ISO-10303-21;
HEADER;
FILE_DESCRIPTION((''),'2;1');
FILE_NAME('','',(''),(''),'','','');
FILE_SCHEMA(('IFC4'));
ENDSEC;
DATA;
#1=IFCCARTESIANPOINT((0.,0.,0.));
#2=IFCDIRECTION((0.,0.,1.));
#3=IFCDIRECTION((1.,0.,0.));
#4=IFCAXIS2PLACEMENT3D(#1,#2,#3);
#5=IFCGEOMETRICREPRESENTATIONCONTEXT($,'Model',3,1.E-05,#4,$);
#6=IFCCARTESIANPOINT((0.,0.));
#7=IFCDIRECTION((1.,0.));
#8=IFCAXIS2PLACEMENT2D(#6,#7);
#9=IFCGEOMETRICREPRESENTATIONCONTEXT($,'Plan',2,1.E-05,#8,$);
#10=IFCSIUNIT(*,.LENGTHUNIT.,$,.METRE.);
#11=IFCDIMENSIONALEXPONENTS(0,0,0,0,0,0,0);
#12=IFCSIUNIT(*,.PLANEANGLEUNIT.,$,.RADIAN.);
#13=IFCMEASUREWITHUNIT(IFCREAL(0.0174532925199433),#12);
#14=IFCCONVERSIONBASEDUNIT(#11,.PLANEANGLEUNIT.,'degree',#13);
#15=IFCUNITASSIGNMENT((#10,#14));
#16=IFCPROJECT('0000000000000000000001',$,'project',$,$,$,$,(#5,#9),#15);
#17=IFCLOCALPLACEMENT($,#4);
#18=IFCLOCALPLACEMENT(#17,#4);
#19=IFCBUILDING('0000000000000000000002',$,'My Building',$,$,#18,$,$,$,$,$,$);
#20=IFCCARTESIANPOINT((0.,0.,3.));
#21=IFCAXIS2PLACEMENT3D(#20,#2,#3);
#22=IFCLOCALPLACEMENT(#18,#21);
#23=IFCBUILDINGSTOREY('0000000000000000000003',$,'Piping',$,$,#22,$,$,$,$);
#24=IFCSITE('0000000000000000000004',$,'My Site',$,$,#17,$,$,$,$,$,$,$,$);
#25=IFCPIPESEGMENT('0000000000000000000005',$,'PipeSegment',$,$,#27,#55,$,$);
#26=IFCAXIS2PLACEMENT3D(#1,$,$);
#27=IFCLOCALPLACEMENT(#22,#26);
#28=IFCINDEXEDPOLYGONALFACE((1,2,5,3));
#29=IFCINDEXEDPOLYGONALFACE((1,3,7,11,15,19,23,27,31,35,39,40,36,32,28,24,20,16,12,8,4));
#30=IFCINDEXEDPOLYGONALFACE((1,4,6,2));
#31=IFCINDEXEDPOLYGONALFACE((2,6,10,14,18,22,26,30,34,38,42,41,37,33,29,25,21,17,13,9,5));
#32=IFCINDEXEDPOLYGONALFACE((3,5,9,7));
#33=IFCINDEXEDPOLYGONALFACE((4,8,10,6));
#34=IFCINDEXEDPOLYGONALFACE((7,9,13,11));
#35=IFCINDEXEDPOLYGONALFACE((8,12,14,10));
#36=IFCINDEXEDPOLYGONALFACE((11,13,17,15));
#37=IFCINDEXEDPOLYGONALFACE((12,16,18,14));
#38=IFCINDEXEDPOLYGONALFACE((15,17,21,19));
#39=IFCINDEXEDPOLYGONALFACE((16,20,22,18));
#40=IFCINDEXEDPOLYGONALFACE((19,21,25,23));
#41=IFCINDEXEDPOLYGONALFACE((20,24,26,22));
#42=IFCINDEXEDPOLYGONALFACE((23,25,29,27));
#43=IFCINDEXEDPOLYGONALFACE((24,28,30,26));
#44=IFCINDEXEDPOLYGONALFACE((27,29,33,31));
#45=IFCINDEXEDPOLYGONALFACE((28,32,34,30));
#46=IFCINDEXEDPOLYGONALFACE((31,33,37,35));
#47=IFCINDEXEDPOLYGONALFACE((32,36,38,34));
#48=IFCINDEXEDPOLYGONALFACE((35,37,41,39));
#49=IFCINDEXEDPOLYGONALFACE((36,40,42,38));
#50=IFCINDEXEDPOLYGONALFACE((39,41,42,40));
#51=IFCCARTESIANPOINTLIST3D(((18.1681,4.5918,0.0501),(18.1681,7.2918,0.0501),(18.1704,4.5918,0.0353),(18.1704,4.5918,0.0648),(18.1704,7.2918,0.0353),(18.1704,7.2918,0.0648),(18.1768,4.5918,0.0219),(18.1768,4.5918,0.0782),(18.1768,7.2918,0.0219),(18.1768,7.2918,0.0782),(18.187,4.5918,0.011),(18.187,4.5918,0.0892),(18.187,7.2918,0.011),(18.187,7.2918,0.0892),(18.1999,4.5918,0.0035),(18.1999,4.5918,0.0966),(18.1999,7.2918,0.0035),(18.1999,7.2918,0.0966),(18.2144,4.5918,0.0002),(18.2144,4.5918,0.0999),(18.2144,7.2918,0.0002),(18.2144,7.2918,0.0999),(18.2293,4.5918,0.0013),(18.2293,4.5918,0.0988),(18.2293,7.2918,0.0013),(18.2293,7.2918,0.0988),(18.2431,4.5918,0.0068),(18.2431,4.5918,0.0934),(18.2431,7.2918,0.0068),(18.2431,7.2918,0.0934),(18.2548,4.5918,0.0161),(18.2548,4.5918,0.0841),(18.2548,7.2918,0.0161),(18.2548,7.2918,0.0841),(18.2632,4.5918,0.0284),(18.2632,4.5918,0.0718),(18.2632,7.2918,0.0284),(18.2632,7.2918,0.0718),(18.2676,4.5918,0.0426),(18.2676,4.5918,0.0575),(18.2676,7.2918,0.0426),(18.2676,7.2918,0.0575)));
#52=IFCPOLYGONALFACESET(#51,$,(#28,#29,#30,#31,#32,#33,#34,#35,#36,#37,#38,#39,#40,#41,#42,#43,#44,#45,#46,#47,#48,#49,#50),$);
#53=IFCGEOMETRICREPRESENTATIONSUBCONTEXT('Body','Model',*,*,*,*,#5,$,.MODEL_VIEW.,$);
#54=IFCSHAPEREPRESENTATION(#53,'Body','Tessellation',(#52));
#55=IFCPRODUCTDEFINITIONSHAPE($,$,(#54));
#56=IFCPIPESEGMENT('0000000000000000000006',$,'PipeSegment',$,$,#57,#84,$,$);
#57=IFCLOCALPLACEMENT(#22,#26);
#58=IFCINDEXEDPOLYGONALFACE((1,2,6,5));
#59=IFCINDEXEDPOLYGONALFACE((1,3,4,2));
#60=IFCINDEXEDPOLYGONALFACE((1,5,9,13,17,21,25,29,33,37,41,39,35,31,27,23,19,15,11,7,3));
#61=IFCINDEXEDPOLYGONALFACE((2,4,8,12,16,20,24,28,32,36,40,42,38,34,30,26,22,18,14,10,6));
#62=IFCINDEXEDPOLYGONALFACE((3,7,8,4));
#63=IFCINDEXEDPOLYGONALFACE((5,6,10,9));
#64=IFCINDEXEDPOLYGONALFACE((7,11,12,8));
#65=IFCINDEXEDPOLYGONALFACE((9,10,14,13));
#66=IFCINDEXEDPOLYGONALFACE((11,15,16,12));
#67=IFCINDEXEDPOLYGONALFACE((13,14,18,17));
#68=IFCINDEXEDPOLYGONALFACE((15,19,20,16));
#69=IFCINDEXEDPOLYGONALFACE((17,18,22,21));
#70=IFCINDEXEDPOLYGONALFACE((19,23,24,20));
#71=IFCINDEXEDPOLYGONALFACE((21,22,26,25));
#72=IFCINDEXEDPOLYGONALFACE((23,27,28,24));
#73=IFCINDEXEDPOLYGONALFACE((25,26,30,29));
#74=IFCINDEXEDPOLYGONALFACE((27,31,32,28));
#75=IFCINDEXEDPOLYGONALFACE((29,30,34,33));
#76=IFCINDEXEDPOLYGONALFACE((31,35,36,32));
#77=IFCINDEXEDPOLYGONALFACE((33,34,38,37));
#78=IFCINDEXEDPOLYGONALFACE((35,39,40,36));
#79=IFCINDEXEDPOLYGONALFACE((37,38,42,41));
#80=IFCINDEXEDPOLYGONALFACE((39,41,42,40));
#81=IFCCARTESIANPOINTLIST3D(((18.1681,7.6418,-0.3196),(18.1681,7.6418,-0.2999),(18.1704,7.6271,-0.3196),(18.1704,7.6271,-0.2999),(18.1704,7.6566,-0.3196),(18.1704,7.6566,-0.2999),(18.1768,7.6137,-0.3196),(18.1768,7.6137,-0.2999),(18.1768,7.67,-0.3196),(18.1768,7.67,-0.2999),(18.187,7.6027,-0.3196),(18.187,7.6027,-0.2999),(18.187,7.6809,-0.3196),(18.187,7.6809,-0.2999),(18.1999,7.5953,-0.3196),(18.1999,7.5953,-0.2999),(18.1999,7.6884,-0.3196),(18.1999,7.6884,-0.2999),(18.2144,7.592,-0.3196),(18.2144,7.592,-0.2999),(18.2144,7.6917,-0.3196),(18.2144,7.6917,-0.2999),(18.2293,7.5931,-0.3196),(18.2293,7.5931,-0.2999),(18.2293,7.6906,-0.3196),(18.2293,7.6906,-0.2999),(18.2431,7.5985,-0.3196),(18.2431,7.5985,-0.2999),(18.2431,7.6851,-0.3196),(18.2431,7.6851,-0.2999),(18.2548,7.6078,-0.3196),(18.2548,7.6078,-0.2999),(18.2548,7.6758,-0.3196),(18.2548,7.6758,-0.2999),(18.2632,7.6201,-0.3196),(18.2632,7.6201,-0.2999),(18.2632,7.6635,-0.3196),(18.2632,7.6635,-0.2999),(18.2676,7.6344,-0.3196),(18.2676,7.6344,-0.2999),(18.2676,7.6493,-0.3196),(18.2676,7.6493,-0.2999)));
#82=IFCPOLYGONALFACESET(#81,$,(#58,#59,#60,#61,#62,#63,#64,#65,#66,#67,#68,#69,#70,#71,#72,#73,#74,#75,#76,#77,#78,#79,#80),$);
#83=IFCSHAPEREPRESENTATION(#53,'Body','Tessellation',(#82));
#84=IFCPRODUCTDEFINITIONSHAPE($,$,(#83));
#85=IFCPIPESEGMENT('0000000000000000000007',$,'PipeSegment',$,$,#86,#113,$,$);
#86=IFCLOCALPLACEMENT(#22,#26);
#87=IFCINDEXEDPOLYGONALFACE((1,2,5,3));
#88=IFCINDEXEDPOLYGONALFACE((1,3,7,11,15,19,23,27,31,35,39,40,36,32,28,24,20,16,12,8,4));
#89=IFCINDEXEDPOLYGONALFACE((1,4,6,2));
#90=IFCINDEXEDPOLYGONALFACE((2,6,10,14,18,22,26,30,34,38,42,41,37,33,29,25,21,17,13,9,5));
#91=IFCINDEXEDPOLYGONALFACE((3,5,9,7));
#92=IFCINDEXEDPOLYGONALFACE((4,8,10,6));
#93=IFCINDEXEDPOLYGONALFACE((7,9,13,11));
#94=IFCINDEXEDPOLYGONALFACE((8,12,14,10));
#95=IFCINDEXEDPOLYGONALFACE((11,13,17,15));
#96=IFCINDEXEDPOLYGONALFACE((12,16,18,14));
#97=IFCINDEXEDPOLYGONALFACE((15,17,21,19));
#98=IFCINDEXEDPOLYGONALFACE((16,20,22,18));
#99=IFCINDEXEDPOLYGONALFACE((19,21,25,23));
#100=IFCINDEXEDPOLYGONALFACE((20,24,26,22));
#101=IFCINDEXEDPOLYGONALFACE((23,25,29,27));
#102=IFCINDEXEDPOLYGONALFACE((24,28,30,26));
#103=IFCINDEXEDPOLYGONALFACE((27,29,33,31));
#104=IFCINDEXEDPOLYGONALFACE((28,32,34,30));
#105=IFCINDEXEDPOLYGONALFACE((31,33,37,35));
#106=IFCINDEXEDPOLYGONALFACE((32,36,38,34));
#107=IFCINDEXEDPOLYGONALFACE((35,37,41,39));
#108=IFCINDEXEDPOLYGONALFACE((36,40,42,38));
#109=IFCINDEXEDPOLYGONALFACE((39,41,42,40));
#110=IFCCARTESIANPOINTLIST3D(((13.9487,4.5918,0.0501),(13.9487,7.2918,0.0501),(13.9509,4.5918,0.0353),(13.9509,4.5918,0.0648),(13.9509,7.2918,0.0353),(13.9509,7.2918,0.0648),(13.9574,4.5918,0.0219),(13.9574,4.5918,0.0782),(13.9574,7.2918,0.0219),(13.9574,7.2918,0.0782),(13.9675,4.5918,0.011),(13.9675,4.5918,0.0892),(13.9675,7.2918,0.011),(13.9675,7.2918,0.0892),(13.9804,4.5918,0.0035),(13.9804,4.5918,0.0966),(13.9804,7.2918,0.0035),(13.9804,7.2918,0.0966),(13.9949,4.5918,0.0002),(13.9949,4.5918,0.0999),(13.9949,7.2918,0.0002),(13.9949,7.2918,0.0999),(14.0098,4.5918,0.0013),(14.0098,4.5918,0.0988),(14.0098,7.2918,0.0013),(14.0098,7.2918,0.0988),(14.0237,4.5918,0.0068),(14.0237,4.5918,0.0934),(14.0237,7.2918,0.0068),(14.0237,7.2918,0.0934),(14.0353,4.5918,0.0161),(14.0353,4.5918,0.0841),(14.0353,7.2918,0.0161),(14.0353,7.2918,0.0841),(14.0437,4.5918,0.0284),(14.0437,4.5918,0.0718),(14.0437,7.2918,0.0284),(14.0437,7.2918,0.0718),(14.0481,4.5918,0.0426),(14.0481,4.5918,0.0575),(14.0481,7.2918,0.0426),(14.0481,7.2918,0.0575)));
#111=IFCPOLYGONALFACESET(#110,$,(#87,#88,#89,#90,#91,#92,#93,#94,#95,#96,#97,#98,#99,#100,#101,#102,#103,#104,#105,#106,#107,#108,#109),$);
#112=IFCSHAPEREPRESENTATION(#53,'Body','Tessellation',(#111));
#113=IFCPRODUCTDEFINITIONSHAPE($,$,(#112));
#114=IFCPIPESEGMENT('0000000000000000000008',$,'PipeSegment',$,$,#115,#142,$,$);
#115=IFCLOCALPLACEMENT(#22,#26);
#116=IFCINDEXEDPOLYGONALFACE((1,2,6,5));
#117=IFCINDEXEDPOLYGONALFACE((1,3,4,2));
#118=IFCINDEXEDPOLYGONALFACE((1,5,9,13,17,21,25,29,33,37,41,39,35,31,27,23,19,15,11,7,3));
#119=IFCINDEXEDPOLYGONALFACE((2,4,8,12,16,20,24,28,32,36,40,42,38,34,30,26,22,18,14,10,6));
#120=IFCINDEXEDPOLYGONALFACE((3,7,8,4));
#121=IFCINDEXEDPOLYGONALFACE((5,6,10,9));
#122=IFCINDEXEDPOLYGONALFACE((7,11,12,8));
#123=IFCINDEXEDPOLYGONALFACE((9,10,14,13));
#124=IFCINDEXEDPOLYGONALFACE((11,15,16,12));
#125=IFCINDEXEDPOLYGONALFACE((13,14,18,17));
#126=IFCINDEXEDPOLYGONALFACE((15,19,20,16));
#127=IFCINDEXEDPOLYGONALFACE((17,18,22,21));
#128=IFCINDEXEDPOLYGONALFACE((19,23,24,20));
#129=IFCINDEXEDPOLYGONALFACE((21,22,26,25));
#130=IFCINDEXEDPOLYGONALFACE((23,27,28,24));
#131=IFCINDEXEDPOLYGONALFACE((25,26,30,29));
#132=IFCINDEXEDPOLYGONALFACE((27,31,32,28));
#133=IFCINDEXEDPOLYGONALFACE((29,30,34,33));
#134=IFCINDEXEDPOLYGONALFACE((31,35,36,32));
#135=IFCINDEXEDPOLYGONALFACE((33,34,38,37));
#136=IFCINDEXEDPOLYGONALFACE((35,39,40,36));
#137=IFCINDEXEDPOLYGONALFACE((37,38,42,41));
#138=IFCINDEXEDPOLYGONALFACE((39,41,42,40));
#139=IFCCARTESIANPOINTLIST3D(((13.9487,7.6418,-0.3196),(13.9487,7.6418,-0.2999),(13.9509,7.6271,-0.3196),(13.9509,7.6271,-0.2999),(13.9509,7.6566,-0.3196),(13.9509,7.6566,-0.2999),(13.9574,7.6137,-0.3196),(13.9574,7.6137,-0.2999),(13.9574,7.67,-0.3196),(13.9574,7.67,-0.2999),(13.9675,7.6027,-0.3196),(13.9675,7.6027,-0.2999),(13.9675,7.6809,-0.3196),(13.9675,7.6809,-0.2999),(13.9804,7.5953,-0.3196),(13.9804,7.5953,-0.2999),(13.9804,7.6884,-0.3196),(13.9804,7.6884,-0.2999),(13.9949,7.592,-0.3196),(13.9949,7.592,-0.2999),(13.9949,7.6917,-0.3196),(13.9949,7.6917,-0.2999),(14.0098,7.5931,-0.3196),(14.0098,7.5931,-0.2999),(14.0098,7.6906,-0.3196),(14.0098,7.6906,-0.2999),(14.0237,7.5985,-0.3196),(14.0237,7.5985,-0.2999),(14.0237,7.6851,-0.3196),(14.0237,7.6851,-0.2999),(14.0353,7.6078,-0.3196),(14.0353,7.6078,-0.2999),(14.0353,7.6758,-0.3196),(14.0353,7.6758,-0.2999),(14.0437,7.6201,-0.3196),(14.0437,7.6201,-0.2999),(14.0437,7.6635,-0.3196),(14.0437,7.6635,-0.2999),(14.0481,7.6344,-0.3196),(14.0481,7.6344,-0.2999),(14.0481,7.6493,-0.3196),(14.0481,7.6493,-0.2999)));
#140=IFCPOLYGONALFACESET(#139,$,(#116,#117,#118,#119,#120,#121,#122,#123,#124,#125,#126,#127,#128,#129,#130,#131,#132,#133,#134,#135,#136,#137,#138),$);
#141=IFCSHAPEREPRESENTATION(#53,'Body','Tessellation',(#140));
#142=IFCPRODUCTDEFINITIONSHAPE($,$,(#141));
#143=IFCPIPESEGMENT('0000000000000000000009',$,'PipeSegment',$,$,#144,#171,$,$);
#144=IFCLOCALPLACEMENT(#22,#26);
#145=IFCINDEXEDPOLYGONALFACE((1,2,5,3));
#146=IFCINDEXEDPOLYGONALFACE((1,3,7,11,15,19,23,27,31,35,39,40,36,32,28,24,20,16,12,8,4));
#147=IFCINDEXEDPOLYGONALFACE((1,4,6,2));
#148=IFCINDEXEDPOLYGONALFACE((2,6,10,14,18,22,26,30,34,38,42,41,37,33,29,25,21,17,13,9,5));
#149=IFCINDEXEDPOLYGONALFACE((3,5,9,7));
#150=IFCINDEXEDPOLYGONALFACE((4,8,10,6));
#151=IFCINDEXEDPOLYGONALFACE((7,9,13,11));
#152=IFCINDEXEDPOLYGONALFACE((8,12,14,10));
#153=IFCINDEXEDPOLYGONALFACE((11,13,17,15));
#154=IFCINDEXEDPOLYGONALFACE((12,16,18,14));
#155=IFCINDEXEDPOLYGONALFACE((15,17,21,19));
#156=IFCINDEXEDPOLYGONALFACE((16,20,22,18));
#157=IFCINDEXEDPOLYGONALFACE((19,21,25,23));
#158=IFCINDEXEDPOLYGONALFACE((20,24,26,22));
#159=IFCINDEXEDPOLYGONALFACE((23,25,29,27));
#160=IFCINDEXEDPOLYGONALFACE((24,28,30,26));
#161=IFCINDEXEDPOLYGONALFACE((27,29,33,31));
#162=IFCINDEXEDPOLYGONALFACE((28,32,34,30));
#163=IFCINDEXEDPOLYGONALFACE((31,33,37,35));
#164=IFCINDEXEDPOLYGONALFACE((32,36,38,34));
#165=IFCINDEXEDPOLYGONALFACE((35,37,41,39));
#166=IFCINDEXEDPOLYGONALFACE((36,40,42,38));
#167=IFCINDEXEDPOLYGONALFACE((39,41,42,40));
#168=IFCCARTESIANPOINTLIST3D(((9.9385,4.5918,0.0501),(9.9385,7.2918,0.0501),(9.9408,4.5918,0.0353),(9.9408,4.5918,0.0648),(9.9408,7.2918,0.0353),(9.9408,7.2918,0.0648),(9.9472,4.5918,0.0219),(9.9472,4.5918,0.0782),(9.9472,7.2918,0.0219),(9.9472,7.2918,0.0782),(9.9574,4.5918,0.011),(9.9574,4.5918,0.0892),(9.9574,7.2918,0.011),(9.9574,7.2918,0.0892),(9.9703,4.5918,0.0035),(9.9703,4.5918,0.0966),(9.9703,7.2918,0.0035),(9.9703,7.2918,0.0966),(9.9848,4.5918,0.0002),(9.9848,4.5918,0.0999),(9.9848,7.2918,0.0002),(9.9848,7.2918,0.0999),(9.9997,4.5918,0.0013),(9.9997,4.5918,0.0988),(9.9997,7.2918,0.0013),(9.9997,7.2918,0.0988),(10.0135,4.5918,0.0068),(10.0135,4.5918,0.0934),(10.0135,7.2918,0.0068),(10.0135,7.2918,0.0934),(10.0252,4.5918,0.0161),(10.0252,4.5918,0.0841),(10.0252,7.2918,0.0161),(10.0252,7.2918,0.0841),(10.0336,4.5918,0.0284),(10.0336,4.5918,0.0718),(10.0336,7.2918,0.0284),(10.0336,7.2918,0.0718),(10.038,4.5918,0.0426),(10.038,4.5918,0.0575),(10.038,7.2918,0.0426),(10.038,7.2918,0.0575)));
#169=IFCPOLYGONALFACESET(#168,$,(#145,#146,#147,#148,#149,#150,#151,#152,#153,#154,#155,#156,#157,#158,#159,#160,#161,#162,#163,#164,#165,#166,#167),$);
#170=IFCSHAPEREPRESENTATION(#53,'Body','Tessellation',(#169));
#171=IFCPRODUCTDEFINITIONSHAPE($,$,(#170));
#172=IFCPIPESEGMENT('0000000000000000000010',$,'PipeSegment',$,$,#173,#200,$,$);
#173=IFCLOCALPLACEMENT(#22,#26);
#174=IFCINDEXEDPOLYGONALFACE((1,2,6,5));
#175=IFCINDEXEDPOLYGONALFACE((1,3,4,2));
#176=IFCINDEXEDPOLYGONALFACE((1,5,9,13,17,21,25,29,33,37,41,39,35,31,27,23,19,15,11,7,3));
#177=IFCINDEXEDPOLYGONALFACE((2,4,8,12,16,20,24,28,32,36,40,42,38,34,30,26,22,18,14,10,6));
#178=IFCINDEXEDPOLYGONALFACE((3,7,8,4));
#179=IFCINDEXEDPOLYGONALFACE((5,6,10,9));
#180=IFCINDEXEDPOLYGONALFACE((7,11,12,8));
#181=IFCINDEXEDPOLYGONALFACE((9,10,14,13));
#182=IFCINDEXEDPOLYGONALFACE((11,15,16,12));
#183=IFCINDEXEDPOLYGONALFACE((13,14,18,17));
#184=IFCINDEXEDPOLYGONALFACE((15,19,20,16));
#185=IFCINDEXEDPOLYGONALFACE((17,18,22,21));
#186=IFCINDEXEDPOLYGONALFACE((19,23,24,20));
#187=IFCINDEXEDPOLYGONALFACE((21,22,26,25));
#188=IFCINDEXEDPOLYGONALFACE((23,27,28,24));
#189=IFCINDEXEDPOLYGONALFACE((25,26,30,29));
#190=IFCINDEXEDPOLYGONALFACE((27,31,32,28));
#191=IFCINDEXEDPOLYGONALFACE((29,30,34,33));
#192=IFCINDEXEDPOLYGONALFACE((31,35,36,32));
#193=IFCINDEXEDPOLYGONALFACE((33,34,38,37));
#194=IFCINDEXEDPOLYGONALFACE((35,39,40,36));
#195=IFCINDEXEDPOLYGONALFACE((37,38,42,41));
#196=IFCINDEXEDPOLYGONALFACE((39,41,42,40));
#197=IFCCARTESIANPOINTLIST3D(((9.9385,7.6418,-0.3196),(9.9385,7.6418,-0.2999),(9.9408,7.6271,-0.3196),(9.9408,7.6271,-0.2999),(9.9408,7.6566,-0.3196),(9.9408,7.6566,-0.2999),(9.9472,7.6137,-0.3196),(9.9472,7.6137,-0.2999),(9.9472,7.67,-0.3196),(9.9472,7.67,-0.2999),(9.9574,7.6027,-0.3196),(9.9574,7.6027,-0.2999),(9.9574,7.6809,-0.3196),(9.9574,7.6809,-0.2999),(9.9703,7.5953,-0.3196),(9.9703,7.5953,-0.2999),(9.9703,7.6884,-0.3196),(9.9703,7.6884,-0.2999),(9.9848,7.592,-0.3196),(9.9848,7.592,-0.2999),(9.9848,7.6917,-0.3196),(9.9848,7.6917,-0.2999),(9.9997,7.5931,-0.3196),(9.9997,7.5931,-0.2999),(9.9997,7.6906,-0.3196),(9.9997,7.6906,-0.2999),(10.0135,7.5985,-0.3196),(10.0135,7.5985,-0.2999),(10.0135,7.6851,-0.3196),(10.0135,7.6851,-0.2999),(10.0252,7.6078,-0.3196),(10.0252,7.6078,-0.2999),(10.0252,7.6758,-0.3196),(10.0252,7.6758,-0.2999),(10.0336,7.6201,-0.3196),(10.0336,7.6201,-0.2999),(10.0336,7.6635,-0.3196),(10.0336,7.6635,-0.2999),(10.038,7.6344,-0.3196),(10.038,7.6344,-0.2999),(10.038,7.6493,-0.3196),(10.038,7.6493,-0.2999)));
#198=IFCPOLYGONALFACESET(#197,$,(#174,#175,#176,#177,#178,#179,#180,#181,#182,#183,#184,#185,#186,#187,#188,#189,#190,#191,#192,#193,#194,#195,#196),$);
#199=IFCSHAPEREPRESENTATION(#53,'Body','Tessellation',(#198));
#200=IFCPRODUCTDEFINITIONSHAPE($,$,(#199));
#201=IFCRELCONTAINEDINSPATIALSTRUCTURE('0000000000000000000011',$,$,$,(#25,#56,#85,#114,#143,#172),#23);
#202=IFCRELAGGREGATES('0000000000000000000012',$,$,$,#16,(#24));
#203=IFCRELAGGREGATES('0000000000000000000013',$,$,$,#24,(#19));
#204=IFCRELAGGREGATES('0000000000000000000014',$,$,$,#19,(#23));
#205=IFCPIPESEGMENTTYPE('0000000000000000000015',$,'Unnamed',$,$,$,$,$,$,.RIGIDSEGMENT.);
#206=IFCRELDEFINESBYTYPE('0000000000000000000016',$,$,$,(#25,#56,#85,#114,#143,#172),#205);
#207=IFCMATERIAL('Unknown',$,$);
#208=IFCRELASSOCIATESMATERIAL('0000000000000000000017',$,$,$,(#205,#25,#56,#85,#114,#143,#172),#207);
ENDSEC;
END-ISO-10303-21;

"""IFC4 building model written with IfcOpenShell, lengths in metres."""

from ifc_helpers import new_model, entity, si_unit, converted_unit, frame, origin_with_axes, origin_2d_with_axis, place, context, subcontext, project, spatial, circle, extrude, material, material_profile, profile_set, profile_usage, type_object, element, save


model = new_model("IFC4")

# Units and contexts
model_context = context("Model", 3, precision=1e-05, world=origin_with_axes())
plan_context = context("Plan", 2, precision=1e-05, world=origin_2d_with_axis())
body_context = subcontext(model_context, "Body", "Model", "MODEL_VIEW")
ifc_project = project(units=[si_unit("LENGTHUNIT", "METRE"), converted_unit("PLANEANGLEUNIT", "degree", entity("IfcReal", 0.0174532925199433), si_unit("PLANEANGLEUNIT", "RADIAN"), dimensions=[0, 0, 0, 0, 0, 0, 0])], contexts=[model_context, plan_context])

# Site, building, storey
site_placement = place(None, origin_with_axes())
site = spatial("IfcSite", under=ifc_project, at=site_placement, Name="My Site")
building_placement = place(site_placement, origin_with_axes())
building = spatial("IfcBuilding", under=site, at=building_placement, Name="My Building")
storey_placement = place(building_placement, frame((0.0, 0.0, 3.0), z_axis=(0.0, 0.0, 1.0), x_axis=(1.0, 0.0, 0.0)))
storey = spatial("IfcBuildingStorey", under=building, at=storey_placement, Name="Piping")

# Pipe segments
ifc_material = material(Name="Unknown")
ifc_material_profile_1 = material_profile(ifc_material, circle(Radius=0.05))
ifc_profile_set_1 = profile_set([ifc_material_profile_1])
ifc_profile_usage_1 = profile_usage(ifc_profile_set_1, cardinal=5)
pipe_segment_type = type_object("IfcPipeSegmentType", Name="Unnamed", PredefinedType="RIGIDSEGMENT", material=ifc_profile_set_1)
pipe_segment_1_placement = place(storey_placement, frame((18.2181, 4.5918, 0.0501), z_axis=(0.0, 1.0, 0.0), x_axis=(-1.0, 0.0, 0.0)))
element("IfcPipeSegment", 1, at=pipe_segment_1_placement, inside=storey, type_object=pipe_segment_type, material=ifc_profile_usage_1, Name="PipeSegment", context=body_context, shape_type="SweptSolid", body=[
    extrude(circle(Radius=0.05), origin_with_axes(), (0.0, 0.0, 1.0), 2.7),
])
ifc_profile_usage_2 = profile_usage(ifc_profile_set_1, cardinal=15)
pipe_segment_2_placement = place(storey_placement, frame((18.2181, 7.6418, -0.2999), z_axis=(0.0, 0.0, -1.0), x_axis=(-1.0, 0.0, 0.0)))
element("IfcPipeSegment", 2, at=pipe_segment_2_placement, inside=storey, type_object=pipe_segment_type, material=ifc_profile_usage_2, Name="PipeSegment", context=body_context, shape_type="SweptSolid", body=[
    extrude(circle(Radius=0.05), origin_with_axes(), (0.0, 0.0, 1.0), 0.0196),
])
ifc_profile_usage_3 = profile_usage(ifc_profile_set_1, cardinal=5)
pipe_segment_3_placement = place(storey_placement, frame((13.9987, 4.5918, 0.0501), z_axis=(0.0, 1.0, 0.0), x_axis=(-1.0, 0.0, 0.0)))
element("IfcPipeSegment", 3, at=pipe_segment_3_placement, inside=storey, type_object=pipe_segment_type, material=ifc_profile_usage_3, Name="PipeSegment", context=body_context, shape_type="SweptSolid", body=[
    extrude(circle(Radius=0.05), origin_with_axes(), (0.0, 0.0, 1.0), 2.7),
])
ifc_profile_usage_4 = profile_usage(ifc_profile_set_1, cardinal=15)
pipe_segment_4_placement = place(storey_placement, frame((13.9987, 7.6418, -0.2999), z_axis=(0.0, 0.0, -1.0), x_axis=(-1.0, 0.0, 0.0)))
element("IfcPipeSegment", 4, at=pipe_segment_4_placement, inside=storey, type_object=pipe_segment_type, material=ifc_profile_usage_4, Name="PipeSegment", context=body_context, shape_type="SweptSolid", body=[
    extrude(circle(Radius=0.05), origin_with_axes(), (0.0, 0.0, 1.0), 0.0196),
])
ifc_profile_usage_5 = profile_usage(ifc_profile_set_1, cardinal=5)
pipe_segment_5_placement = place(storey_placement, frame((9.9885, 4.5918, 0.0501), z_axis=(0.0, 1.0, 0.0), x_axis=(-1.0, 0.0, 0.0)))
element("IfcPipeSegment", 5, at=pipe_segment_5_placement, inside=storey, type_object=pipe_segment_type, material=ifc_profile_usage_5, Name="PipeSegment", context=body_context, shape_type="SweptSolid", body=[
    extrude(circle(Radius=0.05), origin_with_axes(), (0.0, 0.0, 1.0), 2.7),
])
ifc_profile_usage_6 = profile_usage(ifc_profile_set_1, cardinal=15)
pipe_segment_6_placement = place(storey_placement, frame((9.9885, 7.6418, -0.2999), z_axis=(0.0, 0.0, -1.0), x_axis=(-1.0, 0.0, 0.0)))
element("IfcPipeSegment", 6, at=pipe_segment_6_placement, inside=storey, type_object=pipe_segment_type, material=ifc_profile_usage_6, Name="PipeSegment", context=body_context, shape_type="SweptSolid", body=[
    extrude(circle(Radius=0.05), origin_with_axes(), (0.0, 0.0, 1.0), 0.0196),
])

save(model, "model.ifc")
